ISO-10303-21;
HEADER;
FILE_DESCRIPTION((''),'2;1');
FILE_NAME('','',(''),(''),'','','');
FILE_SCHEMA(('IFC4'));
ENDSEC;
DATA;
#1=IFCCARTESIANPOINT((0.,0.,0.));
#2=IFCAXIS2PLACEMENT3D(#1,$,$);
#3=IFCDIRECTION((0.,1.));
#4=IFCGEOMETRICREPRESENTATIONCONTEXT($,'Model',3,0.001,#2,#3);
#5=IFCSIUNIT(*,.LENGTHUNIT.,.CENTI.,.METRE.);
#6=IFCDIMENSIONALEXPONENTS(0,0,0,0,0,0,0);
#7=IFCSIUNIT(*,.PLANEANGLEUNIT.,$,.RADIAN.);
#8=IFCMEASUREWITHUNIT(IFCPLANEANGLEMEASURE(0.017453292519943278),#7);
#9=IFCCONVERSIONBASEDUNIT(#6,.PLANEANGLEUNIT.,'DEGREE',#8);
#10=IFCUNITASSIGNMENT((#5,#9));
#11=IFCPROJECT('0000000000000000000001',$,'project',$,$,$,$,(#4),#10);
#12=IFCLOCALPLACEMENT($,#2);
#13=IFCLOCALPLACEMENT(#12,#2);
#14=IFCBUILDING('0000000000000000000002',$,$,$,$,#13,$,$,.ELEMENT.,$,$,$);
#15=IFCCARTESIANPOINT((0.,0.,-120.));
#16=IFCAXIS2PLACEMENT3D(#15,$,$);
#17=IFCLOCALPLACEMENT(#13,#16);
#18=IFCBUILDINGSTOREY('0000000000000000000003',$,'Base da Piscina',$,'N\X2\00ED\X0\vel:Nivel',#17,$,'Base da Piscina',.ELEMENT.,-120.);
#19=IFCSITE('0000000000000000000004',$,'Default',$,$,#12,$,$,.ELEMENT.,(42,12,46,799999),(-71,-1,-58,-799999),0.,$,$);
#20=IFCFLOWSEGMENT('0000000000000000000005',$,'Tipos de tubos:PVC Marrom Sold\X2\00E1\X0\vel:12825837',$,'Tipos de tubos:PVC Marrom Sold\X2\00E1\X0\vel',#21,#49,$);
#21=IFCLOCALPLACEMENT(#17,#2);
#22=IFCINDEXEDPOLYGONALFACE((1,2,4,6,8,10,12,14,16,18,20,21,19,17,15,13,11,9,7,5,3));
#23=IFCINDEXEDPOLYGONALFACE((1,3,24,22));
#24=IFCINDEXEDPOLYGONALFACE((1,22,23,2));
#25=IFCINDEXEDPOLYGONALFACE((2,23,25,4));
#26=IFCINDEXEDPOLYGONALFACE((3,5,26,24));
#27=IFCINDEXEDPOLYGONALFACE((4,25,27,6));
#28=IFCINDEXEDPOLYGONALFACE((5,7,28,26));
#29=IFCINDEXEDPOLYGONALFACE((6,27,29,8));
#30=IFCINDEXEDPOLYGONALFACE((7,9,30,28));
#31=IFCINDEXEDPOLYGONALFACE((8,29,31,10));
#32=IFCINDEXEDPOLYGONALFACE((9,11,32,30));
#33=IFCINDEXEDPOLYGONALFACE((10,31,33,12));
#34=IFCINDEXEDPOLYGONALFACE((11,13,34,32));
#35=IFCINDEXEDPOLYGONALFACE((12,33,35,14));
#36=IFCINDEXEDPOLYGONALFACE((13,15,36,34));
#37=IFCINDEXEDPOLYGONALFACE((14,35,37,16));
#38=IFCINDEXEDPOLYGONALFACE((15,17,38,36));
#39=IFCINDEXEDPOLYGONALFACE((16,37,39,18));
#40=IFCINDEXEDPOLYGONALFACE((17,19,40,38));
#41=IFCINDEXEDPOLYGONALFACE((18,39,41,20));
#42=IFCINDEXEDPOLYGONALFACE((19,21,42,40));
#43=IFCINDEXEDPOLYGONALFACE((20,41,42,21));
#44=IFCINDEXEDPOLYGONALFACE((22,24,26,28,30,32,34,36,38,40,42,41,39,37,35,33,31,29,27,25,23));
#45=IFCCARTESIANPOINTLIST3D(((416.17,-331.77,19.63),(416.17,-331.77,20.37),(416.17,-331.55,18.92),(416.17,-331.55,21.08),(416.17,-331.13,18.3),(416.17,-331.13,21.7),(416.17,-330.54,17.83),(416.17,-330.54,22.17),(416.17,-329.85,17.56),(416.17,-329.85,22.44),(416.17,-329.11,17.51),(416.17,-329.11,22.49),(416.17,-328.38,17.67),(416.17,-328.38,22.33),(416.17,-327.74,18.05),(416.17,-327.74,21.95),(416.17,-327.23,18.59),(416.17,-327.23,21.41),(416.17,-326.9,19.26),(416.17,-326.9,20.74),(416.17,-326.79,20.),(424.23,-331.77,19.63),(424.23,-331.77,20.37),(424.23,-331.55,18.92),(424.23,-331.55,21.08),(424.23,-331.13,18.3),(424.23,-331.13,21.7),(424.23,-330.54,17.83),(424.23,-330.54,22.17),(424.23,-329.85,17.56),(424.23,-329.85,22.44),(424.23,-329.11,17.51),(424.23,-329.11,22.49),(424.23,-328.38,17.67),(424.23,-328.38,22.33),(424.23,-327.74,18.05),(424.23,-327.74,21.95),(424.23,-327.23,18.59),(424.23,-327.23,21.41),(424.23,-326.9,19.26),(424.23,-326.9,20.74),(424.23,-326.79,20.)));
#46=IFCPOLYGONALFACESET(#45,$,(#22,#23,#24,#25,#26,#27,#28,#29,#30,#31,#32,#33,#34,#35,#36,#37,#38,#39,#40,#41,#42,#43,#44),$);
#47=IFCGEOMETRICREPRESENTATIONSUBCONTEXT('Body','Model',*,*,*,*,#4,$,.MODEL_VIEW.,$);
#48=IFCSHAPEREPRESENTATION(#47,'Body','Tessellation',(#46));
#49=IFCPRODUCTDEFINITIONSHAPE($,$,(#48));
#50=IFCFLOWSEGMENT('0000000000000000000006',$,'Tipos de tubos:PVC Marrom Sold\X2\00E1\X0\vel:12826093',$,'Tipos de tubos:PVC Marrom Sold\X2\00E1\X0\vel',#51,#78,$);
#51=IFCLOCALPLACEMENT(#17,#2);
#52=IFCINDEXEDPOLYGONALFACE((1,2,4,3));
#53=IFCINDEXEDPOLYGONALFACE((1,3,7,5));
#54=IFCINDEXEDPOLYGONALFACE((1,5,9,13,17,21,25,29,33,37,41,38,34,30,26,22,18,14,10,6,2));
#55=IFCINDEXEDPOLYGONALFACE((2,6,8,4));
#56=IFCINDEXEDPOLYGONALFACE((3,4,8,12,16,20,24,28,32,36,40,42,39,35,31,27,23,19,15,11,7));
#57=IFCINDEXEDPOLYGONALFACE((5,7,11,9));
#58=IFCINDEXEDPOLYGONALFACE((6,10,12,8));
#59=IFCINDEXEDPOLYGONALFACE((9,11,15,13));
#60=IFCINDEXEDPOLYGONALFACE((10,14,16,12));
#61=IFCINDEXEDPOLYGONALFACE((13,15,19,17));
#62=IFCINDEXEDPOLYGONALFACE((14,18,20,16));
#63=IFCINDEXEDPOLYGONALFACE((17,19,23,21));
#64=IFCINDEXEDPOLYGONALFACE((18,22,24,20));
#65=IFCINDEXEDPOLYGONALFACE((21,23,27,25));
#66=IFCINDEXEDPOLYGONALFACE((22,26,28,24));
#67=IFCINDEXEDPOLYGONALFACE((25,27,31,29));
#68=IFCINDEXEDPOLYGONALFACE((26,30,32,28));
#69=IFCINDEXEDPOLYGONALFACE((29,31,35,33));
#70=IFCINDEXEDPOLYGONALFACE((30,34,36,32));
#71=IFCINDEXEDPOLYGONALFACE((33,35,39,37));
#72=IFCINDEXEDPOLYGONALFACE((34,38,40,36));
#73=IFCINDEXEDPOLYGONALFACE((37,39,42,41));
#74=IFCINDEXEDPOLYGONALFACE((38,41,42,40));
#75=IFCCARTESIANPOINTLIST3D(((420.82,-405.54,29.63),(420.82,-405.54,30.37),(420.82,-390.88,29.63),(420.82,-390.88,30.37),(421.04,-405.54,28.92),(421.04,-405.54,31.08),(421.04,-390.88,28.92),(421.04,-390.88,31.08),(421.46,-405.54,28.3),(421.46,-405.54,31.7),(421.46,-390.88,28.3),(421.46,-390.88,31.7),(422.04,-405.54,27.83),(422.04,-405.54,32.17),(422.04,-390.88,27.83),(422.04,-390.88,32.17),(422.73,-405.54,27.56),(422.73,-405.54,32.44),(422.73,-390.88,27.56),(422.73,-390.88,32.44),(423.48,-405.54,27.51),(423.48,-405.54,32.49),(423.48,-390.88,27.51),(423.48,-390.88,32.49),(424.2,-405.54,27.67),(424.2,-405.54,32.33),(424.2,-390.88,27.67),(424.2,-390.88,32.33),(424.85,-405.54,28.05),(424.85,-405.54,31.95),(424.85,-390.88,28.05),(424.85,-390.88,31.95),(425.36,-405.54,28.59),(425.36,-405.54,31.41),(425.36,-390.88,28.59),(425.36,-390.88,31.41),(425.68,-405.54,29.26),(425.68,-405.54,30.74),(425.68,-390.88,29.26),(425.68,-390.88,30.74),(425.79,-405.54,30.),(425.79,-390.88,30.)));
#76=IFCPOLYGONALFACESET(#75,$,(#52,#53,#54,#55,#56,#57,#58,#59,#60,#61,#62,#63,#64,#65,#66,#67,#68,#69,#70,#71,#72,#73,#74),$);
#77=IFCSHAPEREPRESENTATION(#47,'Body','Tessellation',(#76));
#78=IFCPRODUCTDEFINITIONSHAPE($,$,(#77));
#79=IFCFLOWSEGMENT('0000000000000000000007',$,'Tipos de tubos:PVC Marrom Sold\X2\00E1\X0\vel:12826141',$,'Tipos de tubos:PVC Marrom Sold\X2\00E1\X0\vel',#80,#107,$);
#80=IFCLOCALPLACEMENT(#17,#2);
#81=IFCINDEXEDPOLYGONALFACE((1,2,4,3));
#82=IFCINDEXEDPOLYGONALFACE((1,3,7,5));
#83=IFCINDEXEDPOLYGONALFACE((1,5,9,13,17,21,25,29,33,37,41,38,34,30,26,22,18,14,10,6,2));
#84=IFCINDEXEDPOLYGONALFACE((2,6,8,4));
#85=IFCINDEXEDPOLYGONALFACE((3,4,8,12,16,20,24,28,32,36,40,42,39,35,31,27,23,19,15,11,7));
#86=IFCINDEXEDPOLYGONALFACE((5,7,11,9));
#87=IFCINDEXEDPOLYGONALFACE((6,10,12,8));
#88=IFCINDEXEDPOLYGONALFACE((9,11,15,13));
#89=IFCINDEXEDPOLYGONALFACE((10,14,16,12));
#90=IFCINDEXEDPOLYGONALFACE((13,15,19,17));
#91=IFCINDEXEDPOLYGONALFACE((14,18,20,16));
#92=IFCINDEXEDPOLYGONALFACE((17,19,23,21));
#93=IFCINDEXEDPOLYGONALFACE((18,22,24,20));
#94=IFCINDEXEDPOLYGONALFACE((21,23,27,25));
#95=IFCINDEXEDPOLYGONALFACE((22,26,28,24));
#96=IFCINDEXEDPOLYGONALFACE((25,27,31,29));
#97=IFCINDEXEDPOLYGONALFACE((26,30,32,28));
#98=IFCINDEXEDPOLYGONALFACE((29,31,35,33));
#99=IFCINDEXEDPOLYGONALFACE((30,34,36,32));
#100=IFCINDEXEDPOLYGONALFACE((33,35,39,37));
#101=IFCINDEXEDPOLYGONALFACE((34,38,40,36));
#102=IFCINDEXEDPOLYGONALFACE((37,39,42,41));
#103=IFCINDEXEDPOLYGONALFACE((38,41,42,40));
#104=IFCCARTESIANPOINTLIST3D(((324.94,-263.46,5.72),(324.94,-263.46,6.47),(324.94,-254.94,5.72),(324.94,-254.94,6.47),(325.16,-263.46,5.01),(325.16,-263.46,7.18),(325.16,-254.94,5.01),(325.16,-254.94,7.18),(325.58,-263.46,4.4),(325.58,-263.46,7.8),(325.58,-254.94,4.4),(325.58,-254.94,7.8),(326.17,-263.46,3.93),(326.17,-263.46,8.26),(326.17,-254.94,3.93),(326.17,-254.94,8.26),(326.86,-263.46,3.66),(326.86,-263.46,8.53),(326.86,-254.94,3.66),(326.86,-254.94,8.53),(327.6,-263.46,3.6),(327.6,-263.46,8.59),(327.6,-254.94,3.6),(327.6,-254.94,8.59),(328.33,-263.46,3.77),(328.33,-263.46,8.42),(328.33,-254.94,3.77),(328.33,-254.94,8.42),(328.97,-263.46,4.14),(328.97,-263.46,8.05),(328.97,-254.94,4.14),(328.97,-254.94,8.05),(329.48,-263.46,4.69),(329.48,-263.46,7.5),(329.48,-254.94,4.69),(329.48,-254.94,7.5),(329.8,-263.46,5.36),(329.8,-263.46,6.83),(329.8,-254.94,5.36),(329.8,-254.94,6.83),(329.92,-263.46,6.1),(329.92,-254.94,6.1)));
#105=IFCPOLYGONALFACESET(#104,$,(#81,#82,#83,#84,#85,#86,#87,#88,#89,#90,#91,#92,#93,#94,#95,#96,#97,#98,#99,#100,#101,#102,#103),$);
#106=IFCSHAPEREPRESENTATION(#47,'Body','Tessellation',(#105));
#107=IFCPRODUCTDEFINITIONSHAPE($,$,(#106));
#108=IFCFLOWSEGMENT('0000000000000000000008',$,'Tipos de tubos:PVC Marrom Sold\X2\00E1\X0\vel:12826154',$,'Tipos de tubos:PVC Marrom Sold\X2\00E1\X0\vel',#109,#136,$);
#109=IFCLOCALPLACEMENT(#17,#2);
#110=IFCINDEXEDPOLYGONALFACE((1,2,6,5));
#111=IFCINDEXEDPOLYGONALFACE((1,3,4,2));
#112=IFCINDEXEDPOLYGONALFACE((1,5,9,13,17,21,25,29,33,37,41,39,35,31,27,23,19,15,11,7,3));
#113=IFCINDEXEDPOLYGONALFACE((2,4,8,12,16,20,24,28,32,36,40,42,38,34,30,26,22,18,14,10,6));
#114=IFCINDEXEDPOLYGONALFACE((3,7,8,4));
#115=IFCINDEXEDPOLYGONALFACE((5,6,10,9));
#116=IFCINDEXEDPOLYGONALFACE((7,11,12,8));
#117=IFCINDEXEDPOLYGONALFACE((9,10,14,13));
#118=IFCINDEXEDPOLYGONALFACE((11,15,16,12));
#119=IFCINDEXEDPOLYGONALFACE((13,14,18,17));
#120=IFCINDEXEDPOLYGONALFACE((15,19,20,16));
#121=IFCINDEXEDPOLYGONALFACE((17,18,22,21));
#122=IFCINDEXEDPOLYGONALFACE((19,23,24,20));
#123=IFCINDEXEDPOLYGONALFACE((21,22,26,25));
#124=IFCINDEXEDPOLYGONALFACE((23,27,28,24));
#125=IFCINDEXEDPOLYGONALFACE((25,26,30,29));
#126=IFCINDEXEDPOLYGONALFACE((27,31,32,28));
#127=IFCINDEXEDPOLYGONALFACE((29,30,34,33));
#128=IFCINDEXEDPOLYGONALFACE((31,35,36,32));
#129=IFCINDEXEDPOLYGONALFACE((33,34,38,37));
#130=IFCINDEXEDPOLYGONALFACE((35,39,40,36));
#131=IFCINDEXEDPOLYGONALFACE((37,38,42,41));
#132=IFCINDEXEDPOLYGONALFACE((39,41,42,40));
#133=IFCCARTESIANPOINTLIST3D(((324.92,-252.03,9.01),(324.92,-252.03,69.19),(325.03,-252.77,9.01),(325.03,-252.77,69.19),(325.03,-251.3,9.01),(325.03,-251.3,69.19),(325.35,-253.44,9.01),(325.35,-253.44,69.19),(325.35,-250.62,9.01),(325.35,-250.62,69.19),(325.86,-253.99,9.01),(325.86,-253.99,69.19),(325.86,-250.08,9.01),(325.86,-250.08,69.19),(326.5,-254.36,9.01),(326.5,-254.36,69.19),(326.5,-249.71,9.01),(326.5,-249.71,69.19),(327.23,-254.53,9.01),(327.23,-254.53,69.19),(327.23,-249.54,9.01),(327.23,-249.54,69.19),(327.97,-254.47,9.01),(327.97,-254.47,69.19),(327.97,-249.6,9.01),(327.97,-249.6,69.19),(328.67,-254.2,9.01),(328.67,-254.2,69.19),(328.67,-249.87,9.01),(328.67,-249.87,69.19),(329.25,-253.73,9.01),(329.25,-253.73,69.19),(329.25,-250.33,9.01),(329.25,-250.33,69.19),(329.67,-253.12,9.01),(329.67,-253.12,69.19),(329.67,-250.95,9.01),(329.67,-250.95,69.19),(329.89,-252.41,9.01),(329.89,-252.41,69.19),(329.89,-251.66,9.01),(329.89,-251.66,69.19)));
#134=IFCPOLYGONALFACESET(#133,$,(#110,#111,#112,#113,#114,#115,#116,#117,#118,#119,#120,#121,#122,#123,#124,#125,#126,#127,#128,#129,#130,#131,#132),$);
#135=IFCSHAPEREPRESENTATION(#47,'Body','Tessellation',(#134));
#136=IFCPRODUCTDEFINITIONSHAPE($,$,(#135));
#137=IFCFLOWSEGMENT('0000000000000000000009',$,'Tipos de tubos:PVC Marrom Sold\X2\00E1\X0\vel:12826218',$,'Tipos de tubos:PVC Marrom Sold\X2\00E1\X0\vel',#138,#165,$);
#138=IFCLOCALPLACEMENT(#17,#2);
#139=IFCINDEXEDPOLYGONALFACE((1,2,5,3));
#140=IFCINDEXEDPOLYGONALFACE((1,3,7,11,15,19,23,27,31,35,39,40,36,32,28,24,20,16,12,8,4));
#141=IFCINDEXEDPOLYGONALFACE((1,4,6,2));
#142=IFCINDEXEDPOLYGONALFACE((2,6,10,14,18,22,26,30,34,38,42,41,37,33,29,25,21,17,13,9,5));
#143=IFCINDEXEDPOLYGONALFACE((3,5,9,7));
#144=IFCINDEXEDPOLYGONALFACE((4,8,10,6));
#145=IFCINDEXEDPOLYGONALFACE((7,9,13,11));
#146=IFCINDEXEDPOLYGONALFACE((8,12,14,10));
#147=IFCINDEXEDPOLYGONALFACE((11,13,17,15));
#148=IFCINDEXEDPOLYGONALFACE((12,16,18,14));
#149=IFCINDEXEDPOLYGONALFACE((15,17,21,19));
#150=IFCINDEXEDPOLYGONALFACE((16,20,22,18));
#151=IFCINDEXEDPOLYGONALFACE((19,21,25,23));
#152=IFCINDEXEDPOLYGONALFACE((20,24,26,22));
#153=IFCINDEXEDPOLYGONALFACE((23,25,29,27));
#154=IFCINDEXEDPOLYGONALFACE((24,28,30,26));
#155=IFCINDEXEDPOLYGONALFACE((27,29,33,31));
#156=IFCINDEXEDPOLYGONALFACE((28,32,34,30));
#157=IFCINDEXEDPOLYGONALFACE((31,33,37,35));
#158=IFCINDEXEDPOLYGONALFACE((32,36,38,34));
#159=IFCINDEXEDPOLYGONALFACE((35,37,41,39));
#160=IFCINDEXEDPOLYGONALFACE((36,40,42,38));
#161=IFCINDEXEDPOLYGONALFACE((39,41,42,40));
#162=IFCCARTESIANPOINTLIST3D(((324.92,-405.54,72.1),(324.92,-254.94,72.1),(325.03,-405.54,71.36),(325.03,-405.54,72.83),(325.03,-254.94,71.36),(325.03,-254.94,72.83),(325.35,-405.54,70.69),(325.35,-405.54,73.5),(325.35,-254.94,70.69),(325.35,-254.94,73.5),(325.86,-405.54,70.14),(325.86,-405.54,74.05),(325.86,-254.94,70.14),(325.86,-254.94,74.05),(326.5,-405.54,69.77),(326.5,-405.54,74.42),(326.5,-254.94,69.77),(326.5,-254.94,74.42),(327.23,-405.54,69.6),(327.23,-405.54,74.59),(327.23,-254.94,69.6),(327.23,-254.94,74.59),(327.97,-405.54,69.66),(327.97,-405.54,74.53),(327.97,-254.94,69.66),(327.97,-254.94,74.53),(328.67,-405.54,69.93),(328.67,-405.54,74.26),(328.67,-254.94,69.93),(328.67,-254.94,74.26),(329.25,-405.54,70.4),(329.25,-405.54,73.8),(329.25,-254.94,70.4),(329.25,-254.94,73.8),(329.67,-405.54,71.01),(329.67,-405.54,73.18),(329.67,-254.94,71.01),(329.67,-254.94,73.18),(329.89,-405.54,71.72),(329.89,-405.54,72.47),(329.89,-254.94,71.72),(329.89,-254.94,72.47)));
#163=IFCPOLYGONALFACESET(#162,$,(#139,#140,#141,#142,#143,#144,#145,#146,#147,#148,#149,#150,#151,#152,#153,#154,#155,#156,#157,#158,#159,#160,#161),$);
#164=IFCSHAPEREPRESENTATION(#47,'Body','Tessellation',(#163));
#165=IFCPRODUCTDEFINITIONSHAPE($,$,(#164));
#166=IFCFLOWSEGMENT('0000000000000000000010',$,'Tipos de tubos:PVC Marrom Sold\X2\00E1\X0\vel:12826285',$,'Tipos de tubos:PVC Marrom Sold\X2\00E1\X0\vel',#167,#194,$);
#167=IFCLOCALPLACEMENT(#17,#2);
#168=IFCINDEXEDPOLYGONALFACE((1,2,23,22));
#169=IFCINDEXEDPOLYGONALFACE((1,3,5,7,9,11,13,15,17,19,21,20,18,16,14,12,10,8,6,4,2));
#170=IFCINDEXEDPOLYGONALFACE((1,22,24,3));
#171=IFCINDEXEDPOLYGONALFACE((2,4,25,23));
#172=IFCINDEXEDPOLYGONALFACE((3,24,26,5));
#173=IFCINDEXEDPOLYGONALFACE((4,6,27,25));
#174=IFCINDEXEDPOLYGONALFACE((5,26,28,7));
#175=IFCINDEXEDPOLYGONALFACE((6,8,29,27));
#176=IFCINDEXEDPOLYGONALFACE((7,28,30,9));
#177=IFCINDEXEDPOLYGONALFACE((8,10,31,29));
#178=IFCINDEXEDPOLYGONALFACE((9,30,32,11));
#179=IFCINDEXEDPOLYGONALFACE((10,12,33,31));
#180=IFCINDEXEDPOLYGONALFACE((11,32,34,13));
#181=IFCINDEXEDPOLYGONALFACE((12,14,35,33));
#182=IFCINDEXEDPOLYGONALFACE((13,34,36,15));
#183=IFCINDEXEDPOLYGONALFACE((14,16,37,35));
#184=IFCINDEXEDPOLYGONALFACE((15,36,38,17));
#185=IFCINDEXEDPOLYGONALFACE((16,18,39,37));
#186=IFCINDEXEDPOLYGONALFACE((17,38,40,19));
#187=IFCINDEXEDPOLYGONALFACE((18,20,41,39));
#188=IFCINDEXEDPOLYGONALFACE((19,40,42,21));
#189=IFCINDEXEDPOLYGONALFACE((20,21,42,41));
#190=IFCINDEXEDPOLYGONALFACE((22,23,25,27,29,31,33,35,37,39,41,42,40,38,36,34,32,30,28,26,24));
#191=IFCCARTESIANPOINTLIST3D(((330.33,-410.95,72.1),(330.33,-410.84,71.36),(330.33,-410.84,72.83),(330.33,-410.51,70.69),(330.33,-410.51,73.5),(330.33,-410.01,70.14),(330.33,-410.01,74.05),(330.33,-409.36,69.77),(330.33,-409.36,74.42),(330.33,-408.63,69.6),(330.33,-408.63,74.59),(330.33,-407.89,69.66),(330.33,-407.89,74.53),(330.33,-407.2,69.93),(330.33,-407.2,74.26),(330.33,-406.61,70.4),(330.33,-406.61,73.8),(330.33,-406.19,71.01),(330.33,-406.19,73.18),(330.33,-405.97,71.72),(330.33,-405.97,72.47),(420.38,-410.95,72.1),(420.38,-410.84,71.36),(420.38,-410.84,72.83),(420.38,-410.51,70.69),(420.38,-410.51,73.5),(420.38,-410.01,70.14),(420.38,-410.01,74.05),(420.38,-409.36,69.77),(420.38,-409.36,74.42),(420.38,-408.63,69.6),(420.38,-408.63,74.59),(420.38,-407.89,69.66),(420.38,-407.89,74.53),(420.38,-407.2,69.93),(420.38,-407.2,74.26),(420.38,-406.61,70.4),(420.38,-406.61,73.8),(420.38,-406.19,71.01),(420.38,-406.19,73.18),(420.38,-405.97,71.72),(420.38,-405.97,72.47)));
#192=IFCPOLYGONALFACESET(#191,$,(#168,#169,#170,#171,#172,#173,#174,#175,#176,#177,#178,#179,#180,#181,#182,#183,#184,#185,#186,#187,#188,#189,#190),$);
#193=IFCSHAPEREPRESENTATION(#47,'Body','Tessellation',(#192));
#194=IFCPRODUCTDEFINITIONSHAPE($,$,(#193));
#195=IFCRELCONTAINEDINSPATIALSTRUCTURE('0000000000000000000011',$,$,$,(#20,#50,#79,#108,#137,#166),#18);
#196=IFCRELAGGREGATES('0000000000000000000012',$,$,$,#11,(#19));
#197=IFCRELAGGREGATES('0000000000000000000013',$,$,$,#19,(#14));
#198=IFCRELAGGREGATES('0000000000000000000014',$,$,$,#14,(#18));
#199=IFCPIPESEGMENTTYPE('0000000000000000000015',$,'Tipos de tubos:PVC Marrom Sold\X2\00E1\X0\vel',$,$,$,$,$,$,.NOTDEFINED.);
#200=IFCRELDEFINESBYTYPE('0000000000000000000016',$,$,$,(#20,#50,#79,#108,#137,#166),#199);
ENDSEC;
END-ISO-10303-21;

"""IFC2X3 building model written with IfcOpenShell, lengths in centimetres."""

from ifc_helpers import new_model, entity, si_unit, converted_unit, direction, frame, frame_2d, origin, origin_2d_with_axis, place, context, subcontext, project, spatial, circle, extrude, type_object, element, save


model = new_model("IFC2X3")

# Units and contexts
model_context = context("Model", 3, precision=0.001, world=origin(), true_north=direction((0.0, 1.0)))
body_context = subcontext(model_context, "Body", "Model", "MODEL_VIEW")
ifc_project = project(units=[si_unit("LENGTHUNIT", "METRE", prefix="CENTI"), converted_unit("PLANEANGLEUNIT", "DEGREE", entity("IfcPlaneAngleMeasure", 0.017453292519943278), si_unit("PLANEANGLEUNIT", "RADIAN"), dimensions=[0, 0, 0, 0, 0, 0, 0])], contexts=[model_context])

# Site, building, storey
site_placement = place(None, origin())
site = spatial("IfcSite", under=ifc_project, at=site_placement, Name="Default", CompositionType="ELEMENT", RefLatitude=(42, 12, 46, 799999), RefLongitude=(-71, -1, -58, -799999), RefElevation=0.0)
building_placement = place(site_placement, origin())
building = spatial("IfcBuilding", under=site, at=building_placement, CompositionType="ELEMENT")
storey_placement = place(building_placement, frame((0.0, 0.0, -120.0)))
storey = spatial("IfcBuildingStorey", under=building, at=storey_placement, Name="Base da Piscina", ObjectType="Nível:Nivel", LongName="Base da Piscina", CompositionType="ELEMENT", Elevation=-120.0)

# Flow segments
pipe_segment_type = type_object("IfcPipeSegmentType", Name="Tipos de tubos:PVC Marrom Soldável", PredefinedType="NOTDEFINED")
flow_segment_1_placement = place(storey_placement, origin())
element("IfcFlowSegment", 1, at=flow_segment_1_placement, inside=storey, type_object=pipe_segment_type, Name="Tipos de tubos:PVC Marrom Soldável:12825837", ObjectType="Tipos de tubos:PVC Marrom Soldável", context=body_context, shape_type="SweptSolid", body=[
    extrude(circle(Radius=2.5, at=frame_2d((0.0, 0.0), x_axis=(1.0, 0.0))), frame((416.17, -329.29, 20.0), z_axis=(1.0, 0.0, 0.0), x_axis=(0.0, 1.0, 0.0)), (0.0, 0.0, 1.0), 8.06),
])
flow_segment_2_placement = place(storey_placement, origin())
element("IfcFlowSegment", 2, at=flow_segment_2_placement, inside=storey, type_object=pipe_segment_type, Name="Tipos de tubos:PVC Marrom Soldável:12826093", ObjectType="Tipos de tubos:PVC Marrom Soldável", context=body_context, shape_type="SweptSolid", body=[
    extrude(circle(Radius=2.5, at=frame_2d((0.0, 0.0), x_axis=(1.0, 0.0))), frame((423.29, -405.54, 30.0), z_axis=(0.0, 1.0, 0.0), x_axis=(1.0, 0.0, 0.0)), (0.0, 0.0, 1.0), 14.66),
])
flow_segment_3_placement = place(storey_placement, origin())
element("IfcFlowSegment", 3, at=flow_segment_3_placement, inside=storey, type_object=pipe_segment_type, Name="Tipos de tubos:PVC Marrom Soldável:12826141", ObjectType="Tipos de tubos:PVC Marrom Soldável", context=body_context, shape_type="SweptSolid", body=[
    extrude(circle(Radius=2.5, at=origin_2d_with_axis()), frame((327.42, -263.46, 6.1), z_axis=(0.0, 1.0, 0.0), x_axis=(1.0, 0.0, 0.0)), (0.0, 0.0, 1.0), 8.51),
])
flow_segment_4_placement = place(storey_placement, origin())
element("IfcFlowSegment", 4, at=flow_segment_4_placement, inside=storey, type_object=pipe_segment_type, Name="Tipos de tubos:PVC Marrom Soldável:12826154", ObjectType="Tipos de tubos:PVC Marrom Soldável", context=body_context, shape_type="SweptSolid", body=[
    extrude(circle(Radius=2.5, at=origin_2d_with_axis()), frame((327.42, -252.03, 9.01), z_axis=(0.0, 0.0, 1.0), x_axis=(-1.0, 0.0, 0.0)), (0.0, 0.0, 1.0), 60.18),
])
flow_segment_5_placement = place(storey_placement, origin())
element("IfcFlowSegment", 5, at=flow_segment_5_placement, inside=storey, type_object=pipe_segment_type, Name="Tipos de tubos:PVC Marrom Soldável:12826218", ObjectType="Tipos de tubos:PVC Marrom Soldável", context=body_context, shape_type="SweptSolid", body=[
    extrude(circle(Radius=2.5, at=frame_2d((0.0, 0.0), x_axis=(1.0, 0.0))), frame((327.42, -405.54, 72.1), z_axis=(0.0, 1.0, 0.0), x_axis=(-1.0, 0.0, 0.0)), (0.0, 0.0, 1.0), 150.59),
])
flow_segment_6_placement = place(storey_placement, origin())
element("IfcFlowSegment", 6, at=flow_segment_6_placement, inside=storey, type_object=pipe_segment_type, Name="Tipos de tubos:PVC Marrom Soldável:12826285", ObjectType="Tipos de tubos:PVC Marrom Soldável", context=body_context, shape_type="SweptSolid", body=[
    extrude(circle(Radius=2.5, at=origin_2d_with_axis()), frame((330.33, -408.45, 72.1), z_axis=(1.0, 0.0, 0.0), x_axis=(0.0, -1.0, 0.0)), (0.0, 0.0, 1.0), 90.05),
])

save(model, "model.ifc")
